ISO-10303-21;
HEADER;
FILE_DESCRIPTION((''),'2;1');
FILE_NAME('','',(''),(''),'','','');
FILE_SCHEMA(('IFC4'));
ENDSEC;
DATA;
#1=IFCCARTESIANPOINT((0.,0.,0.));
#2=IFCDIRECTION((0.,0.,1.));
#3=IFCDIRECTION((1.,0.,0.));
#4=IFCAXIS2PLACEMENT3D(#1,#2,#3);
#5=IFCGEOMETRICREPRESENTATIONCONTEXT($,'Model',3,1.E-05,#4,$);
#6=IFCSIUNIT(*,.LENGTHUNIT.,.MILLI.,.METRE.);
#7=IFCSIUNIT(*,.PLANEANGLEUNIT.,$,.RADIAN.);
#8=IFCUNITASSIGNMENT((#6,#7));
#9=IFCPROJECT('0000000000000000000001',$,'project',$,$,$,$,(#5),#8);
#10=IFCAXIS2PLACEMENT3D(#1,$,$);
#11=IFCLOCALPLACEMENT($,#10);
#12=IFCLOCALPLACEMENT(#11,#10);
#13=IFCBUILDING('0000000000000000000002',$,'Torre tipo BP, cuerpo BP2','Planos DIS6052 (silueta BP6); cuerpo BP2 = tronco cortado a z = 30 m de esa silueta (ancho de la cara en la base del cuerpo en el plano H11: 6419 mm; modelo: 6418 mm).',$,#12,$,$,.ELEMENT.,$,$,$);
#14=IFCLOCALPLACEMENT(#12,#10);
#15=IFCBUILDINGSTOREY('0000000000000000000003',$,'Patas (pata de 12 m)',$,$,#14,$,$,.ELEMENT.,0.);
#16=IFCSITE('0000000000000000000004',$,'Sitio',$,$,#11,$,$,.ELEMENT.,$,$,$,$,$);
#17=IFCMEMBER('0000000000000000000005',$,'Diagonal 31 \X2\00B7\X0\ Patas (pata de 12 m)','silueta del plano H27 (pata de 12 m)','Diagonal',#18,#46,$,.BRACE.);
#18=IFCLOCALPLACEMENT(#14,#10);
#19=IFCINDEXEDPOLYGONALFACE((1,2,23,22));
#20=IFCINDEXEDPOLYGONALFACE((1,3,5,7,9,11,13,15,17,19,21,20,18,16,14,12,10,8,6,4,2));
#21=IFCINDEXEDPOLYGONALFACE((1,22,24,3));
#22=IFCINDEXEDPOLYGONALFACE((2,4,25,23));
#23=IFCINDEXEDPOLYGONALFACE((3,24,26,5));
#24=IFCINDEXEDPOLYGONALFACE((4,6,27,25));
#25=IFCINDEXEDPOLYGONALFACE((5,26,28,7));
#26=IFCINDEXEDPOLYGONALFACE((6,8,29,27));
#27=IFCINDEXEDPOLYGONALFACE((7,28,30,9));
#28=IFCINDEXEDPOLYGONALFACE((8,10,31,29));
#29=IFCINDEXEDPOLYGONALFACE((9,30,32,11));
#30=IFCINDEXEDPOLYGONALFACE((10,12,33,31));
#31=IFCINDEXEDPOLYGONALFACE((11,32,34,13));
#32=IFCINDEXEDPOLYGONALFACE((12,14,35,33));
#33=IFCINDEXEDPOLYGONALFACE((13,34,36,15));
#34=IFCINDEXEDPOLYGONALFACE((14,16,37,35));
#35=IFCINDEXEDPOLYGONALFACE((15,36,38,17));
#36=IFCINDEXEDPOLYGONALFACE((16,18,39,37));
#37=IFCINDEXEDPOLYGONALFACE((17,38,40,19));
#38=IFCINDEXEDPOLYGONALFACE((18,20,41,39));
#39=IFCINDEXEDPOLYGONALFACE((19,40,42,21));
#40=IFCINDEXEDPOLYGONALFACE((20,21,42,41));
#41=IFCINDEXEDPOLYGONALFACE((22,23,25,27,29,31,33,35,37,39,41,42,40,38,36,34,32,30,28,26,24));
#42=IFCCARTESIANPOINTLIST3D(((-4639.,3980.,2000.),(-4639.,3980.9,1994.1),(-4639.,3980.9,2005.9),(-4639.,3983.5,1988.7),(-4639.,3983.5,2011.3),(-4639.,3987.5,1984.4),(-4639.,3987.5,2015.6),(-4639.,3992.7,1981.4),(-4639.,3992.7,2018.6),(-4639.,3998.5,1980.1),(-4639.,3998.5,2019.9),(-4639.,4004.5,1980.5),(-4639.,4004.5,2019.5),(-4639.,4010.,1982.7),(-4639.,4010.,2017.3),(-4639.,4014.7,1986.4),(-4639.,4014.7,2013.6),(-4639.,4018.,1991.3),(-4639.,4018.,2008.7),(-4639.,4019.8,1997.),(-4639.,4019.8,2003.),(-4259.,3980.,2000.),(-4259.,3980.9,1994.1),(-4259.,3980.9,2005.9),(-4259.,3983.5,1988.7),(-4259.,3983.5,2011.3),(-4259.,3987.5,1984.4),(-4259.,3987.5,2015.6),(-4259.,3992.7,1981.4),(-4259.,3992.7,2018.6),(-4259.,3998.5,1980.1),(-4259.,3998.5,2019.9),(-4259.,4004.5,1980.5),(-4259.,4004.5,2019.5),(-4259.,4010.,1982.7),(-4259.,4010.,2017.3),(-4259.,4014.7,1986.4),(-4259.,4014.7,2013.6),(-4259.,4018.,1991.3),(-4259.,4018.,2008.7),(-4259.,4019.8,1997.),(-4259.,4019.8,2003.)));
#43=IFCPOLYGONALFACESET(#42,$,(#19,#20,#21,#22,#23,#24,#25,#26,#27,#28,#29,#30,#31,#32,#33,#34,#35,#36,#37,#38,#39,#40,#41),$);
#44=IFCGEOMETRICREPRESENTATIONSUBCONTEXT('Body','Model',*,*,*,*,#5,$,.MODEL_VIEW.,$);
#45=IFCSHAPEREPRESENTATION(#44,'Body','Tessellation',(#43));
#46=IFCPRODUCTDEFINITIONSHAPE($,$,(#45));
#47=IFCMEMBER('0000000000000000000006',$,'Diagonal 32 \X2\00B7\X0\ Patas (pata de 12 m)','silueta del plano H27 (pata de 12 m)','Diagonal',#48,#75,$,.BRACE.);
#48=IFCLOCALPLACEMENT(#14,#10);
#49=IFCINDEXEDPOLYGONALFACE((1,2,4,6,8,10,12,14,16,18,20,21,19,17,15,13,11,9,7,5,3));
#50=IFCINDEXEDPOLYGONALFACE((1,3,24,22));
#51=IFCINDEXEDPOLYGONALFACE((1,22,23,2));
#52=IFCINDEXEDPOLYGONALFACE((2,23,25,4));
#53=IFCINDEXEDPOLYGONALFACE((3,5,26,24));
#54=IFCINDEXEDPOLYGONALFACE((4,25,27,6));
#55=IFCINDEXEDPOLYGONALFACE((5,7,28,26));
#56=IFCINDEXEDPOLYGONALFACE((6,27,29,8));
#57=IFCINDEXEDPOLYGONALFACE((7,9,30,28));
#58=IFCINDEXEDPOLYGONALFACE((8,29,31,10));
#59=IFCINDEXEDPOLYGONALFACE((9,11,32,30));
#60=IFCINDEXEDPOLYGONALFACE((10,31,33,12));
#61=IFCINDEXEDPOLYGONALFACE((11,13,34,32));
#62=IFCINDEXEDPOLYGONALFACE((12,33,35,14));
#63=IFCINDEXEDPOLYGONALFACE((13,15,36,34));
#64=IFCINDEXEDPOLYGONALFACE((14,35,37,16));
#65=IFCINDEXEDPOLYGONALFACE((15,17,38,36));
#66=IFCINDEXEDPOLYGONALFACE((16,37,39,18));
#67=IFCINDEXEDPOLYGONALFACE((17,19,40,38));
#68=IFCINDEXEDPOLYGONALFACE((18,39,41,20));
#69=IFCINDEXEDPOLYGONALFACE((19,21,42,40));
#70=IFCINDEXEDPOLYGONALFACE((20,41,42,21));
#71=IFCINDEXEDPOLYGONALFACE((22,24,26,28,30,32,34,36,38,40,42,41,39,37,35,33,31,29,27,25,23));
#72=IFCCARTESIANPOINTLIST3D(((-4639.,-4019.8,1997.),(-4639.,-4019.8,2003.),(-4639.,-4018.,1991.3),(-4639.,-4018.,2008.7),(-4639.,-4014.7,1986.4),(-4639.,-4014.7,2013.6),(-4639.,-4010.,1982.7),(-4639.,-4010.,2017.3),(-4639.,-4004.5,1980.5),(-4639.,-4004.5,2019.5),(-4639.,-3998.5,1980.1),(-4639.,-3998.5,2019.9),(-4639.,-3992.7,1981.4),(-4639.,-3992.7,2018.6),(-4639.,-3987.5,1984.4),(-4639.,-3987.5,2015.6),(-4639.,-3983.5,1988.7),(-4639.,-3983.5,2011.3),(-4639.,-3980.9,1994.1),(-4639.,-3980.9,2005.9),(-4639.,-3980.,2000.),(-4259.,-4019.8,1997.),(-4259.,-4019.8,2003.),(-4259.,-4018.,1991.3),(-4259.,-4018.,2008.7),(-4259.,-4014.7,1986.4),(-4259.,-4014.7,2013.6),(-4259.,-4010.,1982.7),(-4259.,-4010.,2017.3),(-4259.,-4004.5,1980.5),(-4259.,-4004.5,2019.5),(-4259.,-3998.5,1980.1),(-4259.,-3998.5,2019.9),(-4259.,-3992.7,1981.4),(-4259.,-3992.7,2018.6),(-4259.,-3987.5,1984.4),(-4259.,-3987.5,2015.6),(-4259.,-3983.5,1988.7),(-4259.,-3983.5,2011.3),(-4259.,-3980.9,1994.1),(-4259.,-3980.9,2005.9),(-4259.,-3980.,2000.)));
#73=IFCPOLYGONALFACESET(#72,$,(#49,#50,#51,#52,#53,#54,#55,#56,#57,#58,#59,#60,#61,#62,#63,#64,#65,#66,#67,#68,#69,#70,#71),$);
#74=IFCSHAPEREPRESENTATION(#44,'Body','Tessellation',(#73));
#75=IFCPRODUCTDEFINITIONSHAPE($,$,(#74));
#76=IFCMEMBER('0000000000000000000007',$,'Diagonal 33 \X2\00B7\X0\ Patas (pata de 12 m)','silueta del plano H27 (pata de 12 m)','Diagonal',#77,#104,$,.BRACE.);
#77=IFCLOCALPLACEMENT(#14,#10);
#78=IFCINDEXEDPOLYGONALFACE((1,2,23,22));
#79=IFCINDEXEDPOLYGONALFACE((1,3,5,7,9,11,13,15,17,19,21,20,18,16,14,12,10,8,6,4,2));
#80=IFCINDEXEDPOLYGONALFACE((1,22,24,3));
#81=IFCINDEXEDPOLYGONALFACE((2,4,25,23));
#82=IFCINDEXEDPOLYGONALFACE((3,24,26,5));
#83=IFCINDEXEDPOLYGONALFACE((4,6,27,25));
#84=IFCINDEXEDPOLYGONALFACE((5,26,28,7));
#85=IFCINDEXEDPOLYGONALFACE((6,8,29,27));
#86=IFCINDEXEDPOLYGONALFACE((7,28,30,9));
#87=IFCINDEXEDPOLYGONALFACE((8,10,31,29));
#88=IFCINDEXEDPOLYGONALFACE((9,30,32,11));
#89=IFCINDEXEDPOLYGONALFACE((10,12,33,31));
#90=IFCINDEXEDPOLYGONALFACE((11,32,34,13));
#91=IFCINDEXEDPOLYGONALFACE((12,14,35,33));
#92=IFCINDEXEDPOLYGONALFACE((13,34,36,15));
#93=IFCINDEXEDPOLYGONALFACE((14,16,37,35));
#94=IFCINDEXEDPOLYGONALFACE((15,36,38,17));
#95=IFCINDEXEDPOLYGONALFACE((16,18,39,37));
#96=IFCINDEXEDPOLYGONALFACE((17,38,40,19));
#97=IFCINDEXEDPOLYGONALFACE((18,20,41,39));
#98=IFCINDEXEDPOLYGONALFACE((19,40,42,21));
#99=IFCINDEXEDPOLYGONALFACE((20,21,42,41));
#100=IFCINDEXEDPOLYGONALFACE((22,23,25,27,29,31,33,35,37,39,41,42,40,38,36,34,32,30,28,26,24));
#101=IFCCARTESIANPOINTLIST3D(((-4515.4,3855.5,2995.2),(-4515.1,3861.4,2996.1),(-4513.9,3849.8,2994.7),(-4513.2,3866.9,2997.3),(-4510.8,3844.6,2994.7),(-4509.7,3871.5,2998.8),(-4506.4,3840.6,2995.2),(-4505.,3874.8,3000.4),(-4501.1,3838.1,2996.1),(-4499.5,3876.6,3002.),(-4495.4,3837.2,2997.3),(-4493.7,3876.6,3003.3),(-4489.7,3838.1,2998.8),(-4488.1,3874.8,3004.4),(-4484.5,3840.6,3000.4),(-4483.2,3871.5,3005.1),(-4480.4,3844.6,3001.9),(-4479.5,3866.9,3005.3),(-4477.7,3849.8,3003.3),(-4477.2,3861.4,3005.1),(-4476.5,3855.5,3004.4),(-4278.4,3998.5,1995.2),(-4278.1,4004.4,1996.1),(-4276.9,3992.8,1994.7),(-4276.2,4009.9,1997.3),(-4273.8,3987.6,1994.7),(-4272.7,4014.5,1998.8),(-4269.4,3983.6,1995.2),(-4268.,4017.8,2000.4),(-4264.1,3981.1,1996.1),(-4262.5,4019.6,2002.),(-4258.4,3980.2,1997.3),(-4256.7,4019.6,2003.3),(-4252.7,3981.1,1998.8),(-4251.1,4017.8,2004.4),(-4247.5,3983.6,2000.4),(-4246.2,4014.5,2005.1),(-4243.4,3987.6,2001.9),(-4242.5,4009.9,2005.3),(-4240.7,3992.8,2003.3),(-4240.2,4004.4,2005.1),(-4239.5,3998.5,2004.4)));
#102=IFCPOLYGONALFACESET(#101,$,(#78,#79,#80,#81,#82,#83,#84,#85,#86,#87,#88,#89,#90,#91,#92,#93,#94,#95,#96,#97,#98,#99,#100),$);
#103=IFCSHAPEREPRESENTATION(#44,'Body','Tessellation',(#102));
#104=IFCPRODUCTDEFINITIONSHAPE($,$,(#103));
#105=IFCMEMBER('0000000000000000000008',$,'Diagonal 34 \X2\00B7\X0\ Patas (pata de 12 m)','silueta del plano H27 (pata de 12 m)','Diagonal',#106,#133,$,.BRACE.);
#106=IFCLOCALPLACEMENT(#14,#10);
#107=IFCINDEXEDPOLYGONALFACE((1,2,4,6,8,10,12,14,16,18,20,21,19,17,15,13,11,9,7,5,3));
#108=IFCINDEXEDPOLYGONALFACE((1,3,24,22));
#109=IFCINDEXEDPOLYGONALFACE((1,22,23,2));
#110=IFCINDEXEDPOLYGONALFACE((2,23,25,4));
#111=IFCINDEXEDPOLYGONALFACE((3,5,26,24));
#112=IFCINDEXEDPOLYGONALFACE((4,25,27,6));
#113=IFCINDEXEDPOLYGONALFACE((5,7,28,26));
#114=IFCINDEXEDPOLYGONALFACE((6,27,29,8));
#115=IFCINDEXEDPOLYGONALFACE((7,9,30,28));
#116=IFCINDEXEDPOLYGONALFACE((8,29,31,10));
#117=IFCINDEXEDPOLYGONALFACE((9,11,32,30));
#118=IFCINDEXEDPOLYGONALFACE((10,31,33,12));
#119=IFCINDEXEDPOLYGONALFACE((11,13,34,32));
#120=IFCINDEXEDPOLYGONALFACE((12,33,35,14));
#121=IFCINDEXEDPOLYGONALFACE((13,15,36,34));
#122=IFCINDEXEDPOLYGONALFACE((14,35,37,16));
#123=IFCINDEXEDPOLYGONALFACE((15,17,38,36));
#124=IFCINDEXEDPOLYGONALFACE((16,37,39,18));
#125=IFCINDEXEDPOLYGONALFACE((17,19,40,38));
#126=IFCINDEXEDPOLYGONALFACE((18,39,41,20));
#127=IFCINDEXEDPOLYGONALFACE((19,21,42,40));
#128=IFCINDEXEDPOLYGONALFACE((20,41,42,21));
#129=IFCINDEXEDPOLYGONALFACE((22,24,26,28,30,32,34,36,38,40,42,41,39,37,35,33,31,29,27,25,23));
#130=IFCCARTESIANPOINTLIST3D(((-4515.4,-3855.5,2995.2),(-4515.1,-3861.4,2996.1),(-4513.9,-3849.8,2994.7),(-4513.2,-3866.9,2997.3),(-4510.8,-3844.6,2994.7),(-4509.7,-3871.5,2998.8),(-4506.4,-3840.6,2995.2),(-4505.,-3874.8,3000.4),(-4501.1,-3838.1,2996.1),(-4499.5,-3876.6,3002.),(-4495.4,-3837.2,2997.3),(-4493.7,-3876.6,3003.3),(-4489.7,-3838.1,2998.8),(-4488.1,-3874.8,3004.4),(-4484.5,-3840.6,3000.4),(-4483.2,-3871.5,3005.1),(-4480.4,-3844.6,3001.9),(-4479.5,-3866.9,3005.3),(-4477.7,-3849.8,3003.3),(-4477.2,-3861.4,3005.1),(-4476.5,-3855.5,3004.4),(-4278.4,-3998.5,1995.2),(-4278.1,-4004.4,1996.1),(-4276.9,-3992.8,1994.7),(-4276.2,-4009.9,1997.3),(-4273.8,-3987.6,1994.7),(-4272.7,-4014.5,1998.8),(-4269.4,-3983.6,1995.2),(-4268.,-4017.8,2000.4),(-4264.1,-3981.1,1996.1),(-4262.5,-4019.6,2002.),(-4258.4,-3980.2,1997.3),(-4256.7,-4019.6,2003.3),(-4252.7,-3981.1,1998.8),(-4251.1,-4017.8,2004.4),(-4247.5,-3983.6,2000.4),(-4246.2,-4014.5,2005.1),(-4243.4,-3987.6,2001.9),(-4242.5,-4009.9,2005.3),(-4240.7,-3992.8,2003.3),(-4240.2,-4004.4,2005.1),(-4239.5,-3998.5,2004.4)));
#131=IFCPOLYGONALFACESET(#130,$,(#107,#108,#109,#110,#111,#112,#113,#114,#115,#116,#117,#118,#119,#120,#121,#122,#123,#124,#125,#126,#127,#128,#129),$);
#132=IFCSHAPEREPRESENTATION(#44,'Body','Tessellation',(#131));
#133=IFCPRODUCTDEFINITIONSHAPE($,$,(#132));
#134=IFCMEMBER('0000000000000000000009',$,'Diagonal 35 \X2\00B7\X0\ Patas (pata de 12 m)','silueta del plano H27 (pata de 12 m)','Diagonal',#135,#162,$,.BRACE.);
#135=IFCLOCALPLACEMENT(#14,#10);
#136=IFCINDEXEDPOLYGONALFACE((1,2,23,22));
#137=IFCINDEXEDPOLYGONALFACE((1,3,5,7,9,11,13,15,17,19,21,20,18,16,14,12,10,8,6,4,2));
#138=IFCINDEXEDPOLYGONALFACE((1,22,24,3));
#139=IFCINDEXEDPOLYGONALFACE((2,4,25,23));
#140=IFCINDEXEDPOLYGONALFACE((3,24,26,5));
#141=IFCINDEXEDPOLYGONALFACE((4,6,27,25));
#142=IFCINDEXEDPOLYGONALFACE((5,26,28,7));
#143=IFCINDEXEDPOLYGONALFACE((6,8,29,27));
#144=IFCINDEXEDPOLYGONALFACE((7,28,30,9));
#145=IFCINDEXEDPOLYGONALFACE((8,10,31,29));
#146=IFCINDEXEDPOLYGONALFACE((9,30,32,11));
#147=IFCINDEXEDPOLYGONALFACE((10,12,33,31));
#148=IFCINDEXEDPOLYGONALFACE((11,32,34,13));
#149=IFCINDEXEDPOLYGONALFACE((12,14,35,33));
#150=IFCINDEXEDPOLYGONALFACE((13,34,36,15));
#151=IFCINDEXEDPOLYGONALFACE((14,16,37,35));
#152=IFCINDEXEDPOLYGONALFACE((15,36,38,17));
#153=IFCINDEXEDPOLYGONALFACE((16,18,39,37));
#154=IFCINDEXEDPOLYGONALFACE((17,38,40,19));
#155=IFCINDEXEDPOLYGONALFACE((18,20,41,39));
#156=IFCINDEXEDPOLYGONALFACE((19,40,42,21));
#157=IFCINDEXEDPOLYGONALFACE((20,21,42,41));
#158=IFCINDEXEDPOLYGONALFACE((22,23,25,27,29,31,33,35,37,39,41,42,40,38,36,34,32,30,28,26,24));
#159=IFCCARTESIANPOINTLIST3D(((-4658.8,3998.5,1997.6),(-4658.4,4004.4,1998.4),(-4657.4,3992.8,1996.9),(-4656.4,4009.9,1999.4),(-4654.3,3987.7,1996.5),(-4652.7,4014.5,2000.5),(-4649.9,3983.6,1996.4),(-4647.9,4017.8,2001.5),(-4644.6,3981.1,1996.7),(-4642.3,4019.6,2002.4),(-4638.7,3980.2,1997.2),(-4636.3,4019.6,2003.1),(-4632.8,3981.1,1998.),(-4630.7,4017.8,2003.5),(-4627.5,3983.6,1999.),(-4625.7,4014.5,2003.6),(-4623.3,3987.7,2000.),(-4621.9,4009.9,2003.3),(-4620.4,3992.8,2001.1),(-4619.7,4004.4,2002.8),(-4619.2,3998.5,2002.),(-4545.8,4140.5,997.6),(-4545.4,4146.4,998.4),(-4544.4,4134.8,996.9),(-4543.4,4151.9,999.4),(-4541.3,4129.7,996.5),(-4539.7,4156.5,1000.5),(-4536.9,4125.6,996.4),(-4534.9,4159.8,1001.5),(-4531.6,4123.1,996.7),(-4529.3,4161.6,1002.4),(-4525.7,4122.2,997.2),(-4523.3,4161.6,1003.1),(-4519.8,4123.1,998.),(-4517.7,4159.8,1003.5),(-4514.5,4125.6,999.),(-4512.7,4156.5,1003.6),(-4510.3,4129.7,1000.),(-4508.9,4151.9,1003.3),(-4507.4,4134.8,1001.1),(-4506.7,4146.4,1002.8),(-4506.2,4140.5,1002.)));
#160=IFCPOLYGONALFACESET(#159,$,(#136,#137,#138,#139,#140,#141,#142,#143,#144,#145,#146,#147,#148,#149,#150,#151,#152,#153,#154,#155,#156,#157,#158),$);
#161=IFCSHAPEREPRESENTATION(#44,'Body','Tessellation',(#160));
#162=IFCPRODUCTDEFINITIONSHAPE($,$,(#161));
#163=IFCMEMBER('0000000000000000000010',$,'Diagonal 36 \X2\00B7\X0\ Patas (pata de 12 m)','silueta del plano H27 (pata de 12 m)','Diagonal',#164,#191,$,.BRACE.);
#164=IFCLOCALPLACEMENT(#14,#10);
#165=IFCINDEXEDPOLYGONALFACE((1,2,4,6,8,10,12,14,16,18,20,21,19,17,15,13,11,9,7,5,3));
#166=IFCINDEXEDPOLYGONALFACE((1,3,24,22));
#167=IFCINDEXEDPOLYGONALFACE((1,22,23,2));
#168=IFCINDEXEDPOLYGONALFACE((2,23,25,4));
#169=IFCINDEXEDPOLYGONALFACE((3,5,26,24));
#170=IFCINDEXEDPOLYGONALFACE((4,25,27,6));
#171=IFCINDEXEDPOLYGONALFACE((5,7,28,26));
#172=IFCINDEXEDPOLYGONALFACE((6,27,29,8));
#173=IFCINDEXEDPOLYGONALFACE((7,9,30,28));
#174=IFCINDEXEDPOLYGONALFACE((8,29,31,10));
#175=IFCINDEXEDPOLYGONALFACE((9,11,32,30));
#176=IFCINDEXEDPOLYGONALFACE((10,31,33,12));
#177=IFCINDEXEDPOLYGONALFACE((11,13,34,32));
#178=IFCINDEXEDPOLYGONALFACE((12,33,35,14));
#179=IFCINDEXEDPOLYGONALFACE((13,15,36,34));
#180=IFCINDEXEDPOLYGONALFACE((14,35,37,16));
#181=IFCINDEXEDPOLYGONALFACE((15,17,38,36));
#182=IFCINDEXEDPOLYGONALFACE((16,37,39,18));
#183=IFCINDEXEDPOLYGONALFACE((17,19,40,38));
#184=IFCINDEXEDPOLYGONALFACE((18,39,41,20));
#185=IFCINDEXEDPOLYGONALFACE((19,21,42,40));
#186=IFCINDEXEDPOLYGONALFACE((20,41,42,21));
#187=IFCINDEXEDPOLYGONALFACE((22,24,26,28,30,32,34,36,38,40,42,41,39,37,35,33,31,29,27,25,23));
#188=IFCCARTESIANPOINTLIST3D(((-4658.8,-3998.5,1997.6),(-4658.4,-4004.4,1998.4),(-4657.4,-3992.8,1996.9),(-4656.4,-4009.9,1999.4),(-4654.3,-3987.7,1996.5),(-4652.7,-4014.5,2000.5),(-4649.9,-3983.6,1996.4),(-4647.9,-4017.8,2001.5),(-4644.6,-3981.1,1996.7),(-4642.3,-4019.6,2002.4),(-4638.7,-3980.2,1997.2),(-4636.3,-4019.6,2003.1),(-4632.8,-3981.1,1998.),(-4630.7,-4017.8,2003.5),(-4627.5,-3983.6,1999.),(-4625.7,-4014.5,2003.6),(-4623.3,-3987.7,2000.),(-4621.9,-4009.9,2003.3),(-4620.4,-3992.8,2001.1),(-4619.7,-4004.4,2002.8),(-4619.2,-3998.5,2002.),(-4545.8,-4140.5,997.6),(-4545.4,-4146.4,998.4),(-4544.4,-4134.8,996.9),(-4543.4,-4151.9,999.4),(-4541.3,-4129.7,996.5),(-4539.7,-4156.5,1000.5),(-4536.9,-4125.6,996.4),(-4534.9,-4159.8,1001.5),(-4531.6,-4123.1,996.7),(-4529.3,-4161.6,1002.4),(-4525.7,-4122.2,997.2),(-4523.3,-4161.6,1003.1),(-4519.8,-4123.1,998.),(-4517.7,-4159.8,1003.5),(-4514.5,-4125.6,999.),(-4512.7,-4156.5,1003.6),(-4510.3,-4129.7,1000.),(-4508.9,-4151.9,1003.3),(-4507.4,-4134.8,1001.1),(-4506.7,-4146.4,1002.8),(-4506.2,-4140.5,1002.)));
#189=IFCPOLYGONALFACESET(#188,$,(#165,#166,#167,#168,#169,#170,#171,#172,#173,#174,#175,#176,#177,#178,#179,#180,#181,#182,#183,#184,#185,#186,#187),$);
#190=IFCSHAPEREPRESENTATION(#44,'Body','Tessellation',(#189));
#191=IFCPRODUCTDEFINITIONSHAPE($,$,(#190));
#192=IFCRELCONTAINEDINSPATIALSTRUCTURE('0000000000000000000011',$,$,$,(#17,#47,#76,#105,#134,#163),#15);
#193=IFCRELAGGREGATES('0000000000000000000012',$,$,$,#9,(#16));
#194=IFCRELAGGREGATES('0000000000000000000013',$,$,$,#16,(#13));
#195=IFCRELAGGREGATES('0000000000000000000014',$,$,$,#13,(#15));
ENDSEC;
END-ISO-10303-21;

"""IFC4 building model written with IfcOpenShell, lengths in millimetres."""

from ifc_helpers import new_model, si_unit, frame, origin, origin_with_axes, place, context, subcontext, project, spatial, circle, extrude, element, save


model = new_model("IFC4")

# Units and contexts
model_context = context("Model", 3, precision=1e-05, world=origin_with_axes())
body_context = subcontext(model_context, "Body", "Model", "MODEL_VIEW")
ifc_project = project(units=[si_unit("LENGTHUNIT", "METRE", prefix="MILLI"), si_unit("PLANEANGLEUNIT", "RADIAN")], contexts=[model_context])

# Site, building, storey
site_placement = place(None, origin())
site = spatial("IfcSite", under=ifc_project, at=site_placement, Name="Sitio", CompositionType="ELEMENT")
building_placement = place(site_placement, origin())
building = spatial("IfcBuilding", under=site, at=building_placement, Name="Torre tipo BP, cuerpo BP2", Description="Planos DIS6052 (silueta BP6); cuerpo BP2 = tronco cortado a z = 30 m de esa silueta (ancho de la cara en la base del cuerpo en el plano H11: 6419 mm; modelo: 6418 mm).", CompositionType="ELEMENT")
storey_placement = place(building_placement, origin())
storey = spatial("IfcBuildingStorey", under=building, at=storey_placement, Name="Patas (pata de 12 m)", CompositionType="ELEMENT", Elevation=0.0)

# Members
for number, where, z_axis, x_axis, name in (
    (1, (-4639.0, 4000.0, 2000.0), (1.0, 0.0, 0.0), (0.0, -1.0, 0.0), "Diagonal 31 · Patas (pata de 12 m)"),
    (2, (-4639.0, -4000.0, 2000.0), (1.0, 0.0, 0.0), (0.0, 1.0, 0.0), "Diagonal 32 · Patas (pata de 12 m)"),
):
    element("IfcMember", number, at=place(storey_placement, frame(where, z_axis=z_axis, x_axis=x_axis)), inside=storey, Name=name, Description="silueta del plano H27 (pata de 12 m)", ObjectType="Diagonal", PredefinedType="BRACE", context=body_context, shape_type="SweptSolid", body=[
        extrude(circle(Radius=20.0), None, (0.0, 0.0, 1.0), 380.0),
    ])
for number, where, z_axis, x_axis, name in (
    (3, (-4259.0, 4000.0, 2000.0), (-0.228411, -0.137818, 0.963761), (0.031782, -0.990458, -0.134103), "Diagonal 33 · Patas (pata de 12 m)"),
    (4, (-4259.0, -4000.0, 2000.0), (-0.228411, 0.137818, 0.963761), (0.031782, 0.990458, -0.134103), "Diagonal 34 · Patas (pata de 12 m)"),
):
    element("IfcMember", number, at=place(storey_placement, frame(where, z_axis=z_axis, x_axis=x_axis)), inside=storey, Name=name, Description="silueta del plano H27 (pata de 12 m)", ObjectType="Diagonal", PredefinedType="BRACE", context=body_context, shape_type="SweptSolid", body=[
        extrude(circle(Radius=20.0), None, (0.0, 0.0, 1.0), 1037.6),
    ])
for number, where, z_axis, x_axis, name in (
    (5, (-4526.0, 4142.0, 1000.0), (-0.111184, -0.139718, 0.983929), (0.015688, -0.990191, -0.138834), "Diagonal 35 · Patas (pata de 12 m)"),
    (6, (-4526.0, -4142.0, 1000.0), (-0.111184, 0.139718, 0.983929), (0.015688, 0.990191, -0.138834), "Diagonal 36 · Patas (pata de 12 m)"),
):
    element("IfcMember", number, at=place(storey_placement, frame(where, z_axis=z_axis, x_axis=x_axis)), inside=storey, Name=name, Description="silueta del plano H27 (pata de 12 m)", ObjectType="Diagonal", PredefinedType="BRACE", context=body_context, shape_type="SweptSolid", body=[
        extrude(circle(Radius=20.0), None, (0.0, 0.0, 1.0), 1016.3),
    ])

save(model, "model.ifc")
